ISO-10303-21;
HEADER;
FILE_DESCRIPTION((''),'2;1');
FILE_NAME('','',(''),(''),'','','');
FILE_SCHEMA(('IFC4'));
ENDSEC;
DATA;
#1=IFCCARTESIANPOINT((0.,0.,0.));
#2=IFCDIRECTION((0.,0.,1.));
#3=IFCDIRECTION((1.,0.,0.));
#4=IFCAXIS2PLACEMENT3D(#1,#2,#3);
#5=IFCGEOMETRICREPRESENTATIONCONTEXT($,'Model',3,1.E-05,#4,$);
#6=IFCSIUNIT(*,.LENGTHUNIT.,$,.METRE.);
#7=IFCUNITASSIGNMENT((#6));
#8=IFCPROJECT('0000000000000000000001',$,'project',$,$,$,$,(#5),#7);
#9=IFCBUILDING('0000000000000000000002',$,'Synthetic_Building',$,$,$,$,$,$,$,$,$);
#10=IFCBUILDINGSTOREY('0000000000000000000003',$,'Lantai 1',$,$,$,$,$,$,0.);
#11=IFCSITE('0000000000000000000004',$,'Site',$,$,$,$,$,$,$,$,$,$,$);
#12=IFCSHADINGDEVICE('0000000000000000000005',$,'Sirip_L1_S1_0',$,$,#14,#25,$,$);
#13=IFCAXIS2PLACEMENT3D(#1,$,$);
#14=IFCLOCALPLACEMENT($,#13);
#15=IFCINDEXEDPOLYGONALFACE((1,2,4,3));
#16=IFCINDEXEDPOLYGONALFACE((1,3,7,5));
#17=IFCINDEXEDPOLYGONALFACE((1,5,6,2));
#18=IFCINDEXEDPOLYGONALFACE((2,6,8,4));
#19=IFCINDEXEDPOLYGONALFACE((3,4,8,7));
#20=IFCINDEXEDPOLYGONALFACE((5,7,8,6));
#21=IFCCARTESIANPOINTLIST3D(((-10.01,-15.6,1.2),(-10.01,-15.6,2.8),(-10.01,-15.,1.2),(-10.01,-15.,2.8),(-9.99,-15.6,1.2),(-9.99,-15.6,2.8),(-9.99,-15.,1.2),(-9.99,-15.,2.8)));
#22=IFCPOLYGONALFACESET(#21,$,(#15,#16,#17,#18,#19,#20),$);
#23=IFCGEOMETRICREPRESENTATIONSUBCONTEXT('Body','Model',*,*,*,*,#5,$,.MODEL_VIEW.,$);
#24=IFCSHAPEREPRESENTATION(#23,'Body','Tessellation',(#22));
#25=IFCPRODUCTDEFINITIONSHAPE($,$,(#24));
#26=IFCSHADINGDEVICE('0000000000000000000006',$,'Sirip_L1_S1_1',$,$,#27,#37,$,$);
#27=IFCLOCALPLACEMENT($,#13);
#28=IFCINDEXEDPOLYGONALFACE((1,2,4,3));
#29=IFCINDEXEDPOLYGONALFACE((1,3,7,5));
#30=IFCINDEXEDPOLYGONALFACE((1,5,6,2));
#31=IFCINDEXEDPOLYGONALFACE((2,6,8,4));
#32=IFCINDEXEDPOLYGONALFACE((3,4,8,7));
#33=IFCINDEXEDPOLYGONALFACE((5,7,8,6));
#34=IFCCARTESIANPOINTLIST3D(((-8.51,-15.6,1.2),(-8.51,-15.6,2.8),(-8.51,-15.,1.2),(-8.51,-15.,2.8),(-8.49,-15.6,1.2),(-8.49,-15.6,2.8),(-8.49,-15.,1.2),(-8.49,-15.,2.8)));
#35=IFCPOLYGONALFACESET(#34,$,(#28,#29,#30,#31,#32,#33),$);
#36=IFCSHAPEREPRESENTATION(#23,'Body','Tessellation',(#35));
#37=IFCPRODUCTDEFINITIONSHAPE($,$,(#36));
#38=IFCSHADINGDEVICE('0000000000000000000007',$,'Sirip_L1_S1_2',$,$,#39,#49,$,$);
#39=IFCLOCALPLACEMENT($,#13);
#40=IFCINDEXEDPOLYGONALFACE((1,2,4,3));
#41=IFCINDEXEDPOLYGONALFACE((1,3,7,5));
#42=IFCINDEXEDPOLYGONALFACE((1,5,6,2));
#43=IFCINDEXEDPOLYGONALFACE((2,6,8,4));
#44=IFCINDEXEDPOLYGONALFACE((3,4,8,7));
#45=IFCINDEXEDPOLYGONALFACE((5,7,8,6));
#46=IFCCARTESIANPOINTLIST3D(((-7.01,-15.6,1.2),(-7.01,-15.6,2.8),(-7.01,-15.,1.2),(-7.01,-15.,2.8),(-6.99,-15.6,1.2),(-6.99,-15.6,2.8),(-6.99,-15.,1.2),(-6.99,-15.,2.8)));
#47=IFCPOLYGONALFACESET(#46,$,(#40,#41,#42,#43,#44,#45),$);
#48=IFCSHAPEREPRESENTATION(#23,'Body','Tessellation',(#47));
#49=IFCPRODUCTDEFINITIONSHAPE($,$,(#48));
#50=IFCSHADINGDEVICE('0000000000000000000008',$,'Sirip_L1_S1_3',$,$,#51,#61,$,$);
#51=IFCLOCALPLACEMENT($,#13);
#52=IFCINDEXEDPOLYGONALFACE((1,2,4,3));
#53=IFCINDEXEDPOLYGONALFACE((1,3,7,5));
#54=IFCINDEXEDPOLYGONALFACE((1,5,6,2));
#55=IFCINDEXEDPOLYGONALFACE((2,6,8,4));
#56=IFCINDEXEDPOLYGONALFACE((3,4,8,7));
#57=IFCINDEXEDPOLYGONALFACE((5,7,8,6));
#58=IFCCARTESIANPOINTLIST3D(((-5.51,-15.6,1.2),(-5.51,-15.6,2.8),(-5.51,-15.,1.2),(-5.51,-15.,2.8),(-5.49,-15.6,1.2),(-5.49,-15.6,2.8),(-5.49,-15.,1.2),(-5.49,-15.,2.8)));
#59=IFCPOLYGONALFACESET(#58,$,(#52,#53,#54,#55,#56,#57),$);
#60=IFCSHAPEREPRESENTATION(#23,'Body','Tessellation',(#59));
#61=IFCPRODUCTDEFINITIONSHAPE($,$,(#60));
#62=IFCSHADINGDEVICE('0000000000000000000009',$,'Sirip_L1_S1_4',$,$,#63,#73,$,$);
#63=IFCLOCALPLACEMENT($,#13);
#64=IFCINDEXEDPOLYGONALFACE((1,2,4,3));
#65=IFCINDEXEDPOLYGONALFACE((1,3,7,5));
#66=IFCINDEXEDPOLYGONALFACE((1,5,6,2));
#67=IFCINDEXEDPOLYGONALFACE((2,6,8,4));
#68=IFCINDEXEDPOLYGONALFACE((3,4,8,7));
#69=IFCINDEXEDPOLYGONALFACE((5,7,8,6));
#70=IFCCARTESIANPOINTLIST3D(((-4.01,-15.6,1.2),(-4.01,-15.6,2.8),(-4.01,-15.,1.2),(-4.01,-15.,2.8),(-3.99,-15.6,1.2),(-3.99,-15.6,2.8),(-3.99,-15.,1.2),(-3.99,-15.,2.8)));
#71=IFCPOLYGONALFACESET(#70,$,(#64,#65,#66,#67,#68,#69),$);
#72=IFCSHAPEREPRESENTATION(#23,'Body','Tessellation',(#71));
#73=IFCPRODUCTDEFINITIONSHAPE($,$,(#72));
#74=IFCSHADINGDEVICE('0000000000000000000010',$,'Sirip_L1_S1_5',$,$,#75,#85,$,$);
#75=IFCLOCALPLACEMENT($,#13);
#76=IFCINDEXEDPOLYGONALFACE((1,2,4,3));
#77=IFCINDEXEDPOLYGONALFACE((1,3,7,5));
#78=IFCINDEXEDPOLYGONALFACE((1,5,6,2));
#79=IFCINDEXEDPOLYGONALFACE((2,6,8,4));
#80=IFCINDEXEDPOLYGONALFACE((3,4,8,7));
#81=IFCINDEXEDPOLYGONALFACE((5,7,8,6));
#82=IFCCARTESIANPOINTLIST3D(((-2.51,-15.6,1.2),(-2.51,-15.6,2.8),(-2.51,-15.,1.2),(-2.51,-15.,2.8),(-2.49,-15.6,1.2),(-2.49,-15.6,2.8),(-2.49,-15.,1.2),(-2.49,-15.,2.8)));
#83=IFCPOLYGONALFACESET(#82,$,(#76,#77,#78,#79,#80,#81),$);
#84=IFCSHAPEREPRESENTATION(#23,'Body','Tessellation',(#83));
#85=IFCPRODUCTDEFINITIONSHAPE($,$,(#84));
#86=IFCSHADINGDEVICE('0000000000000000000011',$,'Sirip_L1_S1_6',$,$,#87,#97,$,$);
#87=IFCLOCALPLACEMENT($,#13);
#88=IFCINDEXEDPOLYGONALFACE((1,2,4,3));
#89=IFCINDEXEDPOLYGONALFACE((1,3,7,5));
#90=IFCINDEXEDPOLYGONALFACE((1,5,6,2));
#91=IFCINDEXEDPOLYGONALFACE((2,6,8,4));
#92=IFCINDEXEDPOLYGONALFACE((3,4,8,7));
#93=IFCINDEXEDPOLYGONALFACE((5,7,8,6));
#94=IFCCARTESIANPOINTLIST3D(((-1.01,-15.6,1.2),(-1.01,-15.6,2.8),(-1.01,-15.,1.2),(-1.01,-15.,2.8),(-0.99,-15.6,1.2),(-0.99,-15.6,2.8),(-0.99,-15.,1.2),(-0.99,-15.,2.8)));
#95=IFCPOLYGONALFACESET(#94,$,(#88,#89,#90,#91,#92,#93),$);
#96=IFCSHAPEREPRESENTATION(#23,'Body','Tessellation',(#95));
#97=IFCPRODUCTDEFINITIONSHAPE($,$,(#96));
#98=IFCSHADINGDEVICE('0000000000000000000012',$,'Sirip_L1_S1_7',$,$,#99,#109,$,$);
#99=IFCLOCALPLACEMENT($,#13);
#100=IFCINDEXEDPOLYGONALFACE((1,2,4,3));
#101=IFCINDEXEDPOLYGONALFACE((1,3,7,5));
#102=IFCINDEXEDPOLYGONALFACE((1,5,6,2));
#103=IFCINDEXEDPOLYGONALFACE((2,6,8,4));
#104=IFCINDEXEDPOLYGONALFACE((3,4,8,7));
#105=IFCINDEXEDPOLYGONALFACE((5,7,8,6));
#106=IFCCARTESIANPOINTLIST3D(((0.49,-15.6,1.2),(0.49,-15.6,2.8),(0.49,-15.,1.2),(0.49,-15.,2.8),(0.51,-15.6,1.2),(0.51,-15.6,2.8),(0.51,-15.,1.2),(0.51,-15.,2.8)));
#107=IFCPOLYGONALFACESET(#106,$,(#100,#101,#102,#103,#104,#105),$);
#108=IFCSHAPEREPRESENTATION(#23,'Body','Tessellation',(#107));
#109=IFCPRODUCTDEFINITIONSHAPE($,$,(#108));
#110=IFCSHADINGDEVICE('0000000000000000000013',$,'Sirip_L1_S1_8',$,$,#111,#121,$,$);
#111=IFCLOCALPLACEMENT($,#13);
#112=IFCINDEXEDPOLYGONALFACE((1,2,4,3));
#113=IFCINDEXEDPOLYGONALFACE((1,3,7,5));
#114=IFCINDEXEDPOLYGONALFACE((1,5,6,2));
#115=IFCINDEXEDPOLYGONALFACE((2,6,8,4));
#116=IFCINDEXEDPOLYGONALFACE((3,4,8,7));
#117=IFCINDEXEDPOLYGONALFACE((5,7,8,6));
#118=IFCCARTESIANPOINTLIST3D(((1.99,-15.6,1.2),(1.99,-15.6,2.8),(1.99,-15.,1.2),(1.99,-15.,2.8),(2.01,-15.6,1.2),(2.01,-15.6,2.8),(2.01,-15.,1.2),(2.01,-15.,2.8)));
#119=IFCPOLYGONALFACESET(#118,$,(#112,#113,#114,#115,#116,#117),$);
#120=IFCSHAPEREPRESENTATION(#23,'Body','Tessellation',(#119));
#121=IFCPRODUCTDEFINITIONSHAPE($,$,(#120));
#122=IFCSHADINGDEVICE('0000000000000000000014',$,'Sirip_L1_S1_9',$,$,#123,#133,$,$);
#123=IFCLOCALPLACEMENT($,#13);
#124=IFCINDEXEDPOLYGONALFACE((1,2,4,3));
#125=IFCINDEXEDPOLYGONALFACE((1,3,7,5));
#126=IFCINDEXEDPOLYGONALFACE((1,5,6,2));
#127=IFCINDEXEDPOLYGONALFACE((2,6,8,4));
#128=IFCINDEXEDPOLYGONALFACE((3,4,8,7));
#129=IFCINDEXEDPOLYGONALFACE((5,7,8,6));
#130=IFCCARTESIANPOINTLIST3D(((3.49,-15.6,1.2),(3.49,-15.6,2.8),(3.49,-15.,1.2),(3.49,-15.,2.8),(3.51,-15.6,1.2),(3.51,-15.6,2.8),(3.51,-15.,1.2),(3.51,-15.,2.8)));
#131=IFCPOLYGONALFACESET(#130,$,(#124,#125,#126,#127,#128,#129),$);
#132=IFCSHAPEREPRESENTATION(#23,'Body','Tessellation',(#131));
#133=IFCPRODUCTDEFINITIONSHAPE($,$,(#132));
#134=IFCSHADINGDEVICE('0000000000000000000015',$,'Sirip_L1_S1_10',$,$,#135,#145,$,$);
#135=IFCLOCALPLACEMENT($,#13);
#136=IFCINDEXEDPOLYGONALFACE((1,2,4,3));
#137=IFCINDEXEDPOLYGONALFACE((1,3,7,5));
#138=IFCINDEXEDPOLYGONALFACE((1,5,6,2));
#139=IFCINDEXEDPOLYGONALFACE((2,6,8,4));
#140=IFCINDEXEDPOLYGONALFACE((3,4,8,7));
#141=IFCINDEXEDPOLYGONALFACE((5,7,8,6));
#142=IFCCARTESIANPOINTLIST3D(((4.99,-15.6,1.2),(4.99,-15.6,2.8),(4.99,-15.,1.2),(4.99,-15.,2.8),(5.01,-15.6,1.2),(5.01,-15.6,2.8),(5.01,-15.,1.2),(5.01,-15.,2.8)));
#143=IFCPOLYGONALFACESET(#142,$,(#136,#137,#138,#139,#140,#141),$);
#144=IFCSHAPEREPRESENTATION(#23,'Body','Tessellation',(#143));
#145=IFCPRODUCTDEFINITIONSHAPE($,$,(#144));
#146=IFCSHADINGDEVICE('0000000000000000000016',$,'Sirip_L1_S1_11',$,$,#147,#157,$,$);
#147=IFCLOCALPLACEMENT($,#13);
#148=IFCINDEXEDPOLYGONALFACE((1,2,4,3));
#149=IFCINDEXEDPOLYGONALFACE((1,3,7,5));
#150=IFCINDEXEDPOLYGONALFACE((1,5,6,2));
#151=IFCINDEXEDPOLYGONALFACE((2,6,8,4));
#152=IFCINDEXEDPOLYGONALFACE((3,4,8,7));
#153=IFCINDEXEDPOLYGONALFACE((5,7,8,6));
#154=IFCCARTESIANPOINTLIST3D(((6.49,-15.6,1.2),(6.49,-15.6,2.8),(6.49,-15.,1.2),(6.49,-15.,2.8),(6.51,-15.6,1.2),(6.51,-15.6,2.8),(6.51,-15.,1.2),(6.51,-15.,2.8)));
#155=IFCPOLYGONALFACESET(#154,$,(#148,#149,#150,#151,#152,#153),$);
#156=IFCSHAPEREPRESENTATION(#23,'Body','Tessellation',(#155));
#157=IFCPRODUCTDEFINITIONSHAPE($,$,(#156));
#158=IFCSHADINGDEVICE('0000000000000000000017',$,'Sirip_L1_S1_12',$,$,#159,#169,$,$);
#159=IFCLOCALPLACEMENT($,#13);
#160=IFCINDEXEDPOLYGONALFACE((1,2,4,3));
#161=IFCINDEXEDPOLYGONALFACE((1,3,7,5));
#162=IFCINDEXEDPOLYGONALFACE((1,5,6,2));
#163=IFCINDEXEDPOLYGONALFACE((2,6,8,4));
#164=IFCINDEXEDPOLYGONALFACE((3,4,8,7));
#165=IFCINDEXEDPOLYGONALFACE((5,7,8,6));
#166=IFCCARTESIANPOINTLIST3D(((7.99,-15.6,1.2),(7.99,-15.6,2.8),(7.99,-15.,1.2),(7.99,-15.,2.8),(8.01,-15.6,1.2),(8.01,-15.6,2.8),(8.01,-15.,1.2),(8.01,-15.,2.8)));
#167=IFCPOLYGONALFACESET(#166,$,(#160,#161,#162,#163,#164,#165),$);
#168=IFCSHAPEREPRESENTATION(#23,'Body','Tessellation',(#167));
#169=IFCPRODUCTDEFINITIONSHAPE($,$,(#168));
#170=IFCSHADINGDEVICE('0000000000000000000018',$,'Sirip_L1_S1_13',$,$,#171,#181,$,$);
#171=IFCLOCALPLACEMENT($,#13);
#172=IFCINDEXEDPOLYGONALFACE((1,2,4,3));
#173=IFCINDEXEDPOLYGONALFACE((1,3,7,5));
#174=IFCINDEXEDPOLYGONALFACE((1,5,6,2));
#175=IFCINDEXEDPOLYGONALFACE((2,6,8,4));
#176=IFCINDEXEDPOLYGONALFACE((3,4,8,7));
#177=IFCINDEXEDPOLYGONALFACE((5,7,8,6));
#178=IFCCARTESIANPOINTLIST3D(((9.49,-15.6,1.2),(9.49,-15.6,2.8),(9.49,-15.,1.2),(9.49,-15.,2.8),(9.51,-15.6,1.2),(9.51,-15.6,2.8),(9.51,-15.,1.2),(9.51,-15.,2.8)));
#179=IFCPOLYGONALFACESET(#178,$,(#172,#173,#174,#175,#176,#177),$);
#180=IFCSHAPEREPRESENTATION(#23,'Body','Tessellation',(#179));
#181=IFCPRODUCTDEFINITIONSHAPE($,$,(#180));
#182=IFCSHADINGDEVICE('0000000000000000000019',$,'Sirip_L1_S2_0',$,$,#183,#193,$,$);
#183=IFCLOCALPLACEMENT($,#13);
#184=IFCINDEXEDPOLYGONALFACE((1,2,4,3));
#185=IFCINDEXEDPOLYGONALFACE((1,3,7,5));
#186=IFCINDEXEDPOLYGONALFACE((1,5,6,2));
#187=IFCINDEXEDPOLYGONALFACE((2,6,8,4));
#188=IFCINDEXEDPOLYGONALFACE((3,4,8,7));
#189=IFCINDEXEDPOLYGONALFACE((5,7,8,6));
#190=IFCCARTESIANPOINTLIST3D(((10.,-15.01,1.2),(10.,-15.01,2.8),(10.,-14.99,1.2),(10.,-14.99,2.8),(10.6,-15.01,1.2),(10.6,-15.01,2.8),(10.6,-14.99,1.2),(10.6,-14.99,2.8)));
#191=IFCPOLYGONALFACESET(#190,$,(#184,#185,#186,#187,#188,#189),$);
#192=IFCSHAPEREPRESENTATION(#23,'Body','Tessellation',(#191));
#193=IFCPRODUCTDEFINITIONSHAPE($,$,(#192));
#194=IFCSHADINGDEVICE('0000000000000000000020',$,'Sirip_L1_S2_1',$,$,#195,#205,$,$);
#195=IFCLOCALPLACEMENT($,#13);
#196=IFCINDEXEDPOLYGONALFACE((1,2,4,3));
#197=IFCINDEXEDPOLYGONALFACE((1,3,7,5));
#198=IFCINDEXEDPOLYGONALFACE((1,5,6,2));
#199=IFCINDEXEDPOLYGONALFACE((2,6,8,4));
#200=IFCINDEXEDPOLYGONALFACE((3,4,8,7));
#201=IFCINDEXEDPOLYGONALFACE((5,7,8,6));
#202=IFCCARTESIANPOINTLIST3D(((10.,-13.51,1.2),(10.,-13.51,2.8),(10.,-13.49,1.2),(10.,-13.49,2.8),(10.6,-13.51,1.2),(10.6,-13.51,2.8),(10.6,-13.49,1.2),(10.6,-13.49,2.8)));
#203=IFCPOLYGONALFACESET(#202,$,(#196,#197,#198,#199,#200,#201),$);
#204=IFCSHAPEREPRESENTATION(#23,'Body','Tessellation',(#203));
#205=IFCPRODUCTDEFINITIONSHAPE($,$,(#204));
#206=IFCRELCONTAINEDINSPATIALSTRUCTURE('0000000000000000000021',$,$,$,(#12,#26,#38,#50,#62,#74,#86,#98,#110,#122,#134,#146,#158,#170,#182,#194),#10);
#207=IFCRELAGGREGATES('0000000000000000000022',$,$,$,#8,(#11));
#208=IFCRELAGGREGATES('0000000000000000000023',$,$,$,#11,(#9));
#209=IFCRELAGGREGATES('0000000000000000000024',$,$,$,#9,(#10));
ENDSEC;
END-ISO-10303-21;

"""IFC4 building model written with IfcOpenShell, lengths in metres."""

from ifc_helpers import new_model, si_unit, frame, origin_with_axes, place, context, subcontext, project, spatial, polyline, outline, extrude, element, save


model = new_model("IFC4")

# Units and contexts
model_context = context("Model", 3, precision=1e-05, world=origin_with_axes())
body_context = subcontext(model_context, "Body", "Model", "MODEL_VIEW")
ifc_project = project(units=[si_unit("LENGTHUNIT", "METRE")], contexts=[model_context])

# Site, building, storey
site = spatial("IfcSite", under=ifc_project, Name="Site")
building = spatial("IfcBuilding", under=site, Name="Synthetic_Building")
storey = spatial("IfcBuildingStorey", under=building, Name="Lantai 1", Elevation=0.0)

# Shading devices
shading_device_1_placement = place(None, origin_with_axes())
element("IfcShadingDevice", 1, at=shading_device_1_placement, inside=storey, Name="Sirip_L1_S1_0", context=body_context, shape_type="SweptSolid", body=[
    extrude(outline(polyline([(-10.01, -15.0), (-9.99, -15.0), (-9.99, -15.6), (-10.01, -15.6), (-10.01, -15.0)])), frame((0.0, 0.0, 1.2), z_axis=(0.0, 0.0, 1.0), x_axis=(1.0, 0.0, 0.0)), (0.0, 0.0, 1.0), 1.6),
])
shading_device_2_placement = place(None, origin_with_axes())
element("IfcShadingDevice", 2, at=shading_device_2_placement, inside=storey, Name="Sirip_L1_S1_1", context=body_context, shape_type="SweptSolid", body=[
    extrude(outline(polyline([(-8.51, -15.0), (-8.49, -15.0), (-8.49, -15.6), (-8.51, -15.6), (-8.51, -15.0)])), frame((0.0, 0.0, 1.2), z_axis=(0.0, 0.0, 1.0), x_axis=(1.0, 0.0, 0.0)), (0.0, 0.0, 1.0), 1.6),
])
shading_device_3_placement = place(None, origin_with_axes())
element("IfcShadingDevice", 3, at=shading_device_3_placement, inside=storey, Name="Sirip_L1_S1_2", context=body_context, shape_type="SweptSolid", body=[
    extrude(outline(polyline([(-7.01, -15.0), (-6.99, -15.0), (-6.99, -15.6), (-7.01, -15.6), (-7.01, -15.0)])), frame((0.0, 0.0, 1.2), z_axis=(0.0, 0.0, 1.0), x_axis=(1.0, 0.0, 0.0)), (0.0, 0.0, 1.0), 1.6),
])
shading_device_4_placement = place(None, origin_with_axes())
element("IfcShadingDevice", 4, at=shading_device_4_placement, inside=storey, Name="Sirip_L1_S1_3", context=body_context, shape_type="SweptSolid", body=[
    extrude(outline(polyline([(-5.51, -15.0), (-5.49, -15.0), (-5.49, -15.6), (-5.51, -15.6), (-5.51, -15.0)])), frame((0.0, 0.0, 1.2), z_axis=(0.0, 0.0, 1.0), x_axis=(1.0, 0.0, 0.0)), (0.0, 0.0, 1.0), 1.6),
])
shading_device_5_placement = place(None, origin_with_axes())
element("IfcShadingDevice", 5, at=shading_device_5_placement, inside=storey, Name="Sirip_L1_S1_4", context=body_context, shape_type="SweptSolid", body=[
    extrude(outline(polyline([(-4.01, -15.0), (-3.99, -15.0), (-3.99, -15.6), (-4.01, -15.6), (-4.01, -15.0)])), frame((0.0, 0.0, 1.2), z_axis=(0.0, 0.0, 1.0), x_axis=(1.0, 0.0, 0.0)), (0.0, 0.0, 1.0), 1.6),
])
shading_device_6_placement = place(None, origin_with_axes())
element("IfcShadingDevice", 6, at=shading_device_6_placement, inside=storey, Name="Sirip_L1_S1_5", context=body_context, shape_type="SweptSolid", body=[
    extrude(outline(polyline([(-2.51, -15.0), (-2.49, -15.0), (-2.49, -15.6), (-2.51, -15.6), (-2.51, -15.0)])), frame((0.0, 0.0, 1.2), z_axis=(0.0, 0.0, 1.0), x_axis=(1.0, 0.0, 0.0)), (0.0, 0.0, 1.0), 1.6),
])
shading_device_7_placement = place(None, origin_with_axes())
element("IfcShadingDevice", 7, at=shading_device_7_placement, inside=storey, Name="Sirip_L1_S1_6", context=body_context, shape_type="SweptSolid", body=[
    extrude(outline(polyline([(-1.01, -15.0), (-0.99, -15.0), (-0.99, -15.6), (-1.01, -15.6), (-1.01, -15.0)])), frame((0.0, 0.0, 1.2), z_axis=(0.0, 0.0, 1.0), x_axis=(1.0, 0.0, 0.0)), (0.0, 0.0, 1.0), 1.6),
])
shading_device_8_placement = place(None, origin_with_axes())
element("IfcShadingDevice", 8, at=shading_device_8_placement, inside=storey, Name="Sirip_L1_S1_7", context=body_context, shape_type="SweptSolid", body=[
    extrude(outline(polyline([(0.49, -15.0), (0.51, -15.0), (0.51, -15.6), (0.49, -15.6), (0.49, -15.0)])), frame((0.0, 0.0, 1.2), z_axis=(0.0, 0.0, 1.0), x_axis=(1.0, 0.0, 0.0)), (0.0, 0.0, 1.0), 1.6),
])
shading_device_9_placement = place(None, origin_with_axes())
element("IfcShadingDevice", 9, at=shading_device_9_placement, inside=storey, Name="Sirip_L1_S1_8", context=body_context, shape_type="SweptSolid", body=[
    extrude(outline(polyline([(1.99, -15.0), (2.01, -15.0), (2.01, -15.6), (1.99, -15.6), (1.99, -15.0)])), frame((0.0, 0.0, 1.2), z_axis=(0.0, 0.0, 1.0), x_axis=(1.0, 0.0, 0.0)), (0.0, 0.0, 1.0), 1.6),
])
shading_device_10_placement = place(None, origin_with_axes())
element("IfcShadingDevice", 10, at=shading_device_10_placement, inside=storey, Name="Sirip_L1_S1_9", context=body_context, shape_type="SweptSolid", body=[
    extrude(outline(polyline([(3.49, -15.0), (3.51, -15.0), (3.51, -15.6), (3.49, -15.6), (3.49, -15.0)])), frame((0.0, 0.0, 1.2), z_axis=(0.0, 0.0, 1.0), x_axis=(1.0, 0.0, 0.0)), (0.0, 0.0, 1.0), 1.6),
])
shading_device_11_placement = place(None, origin_with_axes())
element("IfcShadingDevice", 11, at=shading_device_11_placement, inside=storey, Name="Sirip_L1_S1_10", context=body_context, shape_type="SweptSolid", body=[
    extrude(outline(polyline([(4.99, -15.0), (5.01, -15.0), (5.01, -15.6), (4.99, -15.6), (4.99, -15.0)])), frame((0.0, 0.0, 1.2), z_axis=(0.0, 0.0, 1.0), x_axis=(1.0, 0.0, 0.0)), (0.0, 0.0, 1.0), 1.6),
])
shading_device_12_placement = place(None, origin_with_axes())
element("IfcShadingDevice", 12, at=shading_device_12_placement, inside=storey, Name="Sirip_L1_S1_11", context=body_context, shape_type="SweptSolid", body=[
    extrude(outline(polyline([(6.49, -15.0), (6.51, -15.0), (6.51, -15.6), (6.49, -15.6), (6.49, -15.0)])), frame((0.0, 0.0, 1.2), z_axis=(0.0, 0.0, 1.0), x_axis=(1.0, 0.0, 0.0)), (0.0, 0.0, 1.0), 1.6),
])
shading_device_13_placement = place(None, origin_with_axes())
element("IfcShadingDevice", 13, at=shading_device_13_placement, inside=storey, Name="Sirip_L1_S1_12", context=body_context, shape_type="SweptSolid", body=[
    extrude(outline(polyline([(7.99, -15.0), (8.01, -15.0), (8.01, -15.6), (7.99, -15.6), (7.99, -15.0)])), frame((0.0, 0.0, 1.2), z_axis=(0.0, 0.0, 1.0), x_axis=(1.0, 0.0, 0.0)), (0.0, 0.0, 1.0), 1.6),
])
shading_device_14_placement = place(None, origin_with_axes())
element("IfcShadingDevice", 14, at=shading_device_14_placement, inside=storey, Name="Sirip_L1_S1_13", context=body_context, shape_type="SweptSolid", body=[
    extrude(outline(polyline([(9.49, -15.0), (9.51, -15.0), (9.51, -15.6), (9.49, -15.6), (9.49, -15.0)])), frame((0.0, 0.0, 1.2), z_axis=(0.0, 0.0, 1.0), x_axis=(1.0, 0.0, 0.0)), (0.0, 0.0, 1.0), 1.6),
])
shading_device_15_placement = place(None, origin_with_axes())
element("IfcShadingDevice", 15, at=shading_device_15_placement, inside=storey, Name="Sirip_L1_S2_0", context=body_context, shape_type="SweptSolid", body=[
    extrude(outline(polyline([(10.0, -15.01), (10.0, -14.99), (10.6, -14.99), (10.6, -15.01), (10.0, -15.01)])), frame((0.0, 0.0, 1.2), z_axis=(0.0, 0.0, 1.0), x_axis=(1.0, 0.0, 0.0)), (0.0, 0.0, 1.0), 1.6),
])
shading_device_16_placement = place(None, origin_with_axes())
element("IfcShadingDevice", 16, at=shading_device_16_placement, inside=storey, Name="Sirip_L1_S2_1", context=body_context, shape_type="SweptSolid", body=[
    extrude(outline(polyline([(10.0, -13.51), (10.0, -13.49), (10.6, -13.49), (10.6, -13.51), (10.0, -13.51)])), frame((0.0, 0.0, 1.2), z_axis=(0.0, 0.0, 1.0), x_axis=(1.0, 0.0, 0.0)), (0.0, 0.0, 1.0), 1.6),
])

save(model, "model.ifc")
